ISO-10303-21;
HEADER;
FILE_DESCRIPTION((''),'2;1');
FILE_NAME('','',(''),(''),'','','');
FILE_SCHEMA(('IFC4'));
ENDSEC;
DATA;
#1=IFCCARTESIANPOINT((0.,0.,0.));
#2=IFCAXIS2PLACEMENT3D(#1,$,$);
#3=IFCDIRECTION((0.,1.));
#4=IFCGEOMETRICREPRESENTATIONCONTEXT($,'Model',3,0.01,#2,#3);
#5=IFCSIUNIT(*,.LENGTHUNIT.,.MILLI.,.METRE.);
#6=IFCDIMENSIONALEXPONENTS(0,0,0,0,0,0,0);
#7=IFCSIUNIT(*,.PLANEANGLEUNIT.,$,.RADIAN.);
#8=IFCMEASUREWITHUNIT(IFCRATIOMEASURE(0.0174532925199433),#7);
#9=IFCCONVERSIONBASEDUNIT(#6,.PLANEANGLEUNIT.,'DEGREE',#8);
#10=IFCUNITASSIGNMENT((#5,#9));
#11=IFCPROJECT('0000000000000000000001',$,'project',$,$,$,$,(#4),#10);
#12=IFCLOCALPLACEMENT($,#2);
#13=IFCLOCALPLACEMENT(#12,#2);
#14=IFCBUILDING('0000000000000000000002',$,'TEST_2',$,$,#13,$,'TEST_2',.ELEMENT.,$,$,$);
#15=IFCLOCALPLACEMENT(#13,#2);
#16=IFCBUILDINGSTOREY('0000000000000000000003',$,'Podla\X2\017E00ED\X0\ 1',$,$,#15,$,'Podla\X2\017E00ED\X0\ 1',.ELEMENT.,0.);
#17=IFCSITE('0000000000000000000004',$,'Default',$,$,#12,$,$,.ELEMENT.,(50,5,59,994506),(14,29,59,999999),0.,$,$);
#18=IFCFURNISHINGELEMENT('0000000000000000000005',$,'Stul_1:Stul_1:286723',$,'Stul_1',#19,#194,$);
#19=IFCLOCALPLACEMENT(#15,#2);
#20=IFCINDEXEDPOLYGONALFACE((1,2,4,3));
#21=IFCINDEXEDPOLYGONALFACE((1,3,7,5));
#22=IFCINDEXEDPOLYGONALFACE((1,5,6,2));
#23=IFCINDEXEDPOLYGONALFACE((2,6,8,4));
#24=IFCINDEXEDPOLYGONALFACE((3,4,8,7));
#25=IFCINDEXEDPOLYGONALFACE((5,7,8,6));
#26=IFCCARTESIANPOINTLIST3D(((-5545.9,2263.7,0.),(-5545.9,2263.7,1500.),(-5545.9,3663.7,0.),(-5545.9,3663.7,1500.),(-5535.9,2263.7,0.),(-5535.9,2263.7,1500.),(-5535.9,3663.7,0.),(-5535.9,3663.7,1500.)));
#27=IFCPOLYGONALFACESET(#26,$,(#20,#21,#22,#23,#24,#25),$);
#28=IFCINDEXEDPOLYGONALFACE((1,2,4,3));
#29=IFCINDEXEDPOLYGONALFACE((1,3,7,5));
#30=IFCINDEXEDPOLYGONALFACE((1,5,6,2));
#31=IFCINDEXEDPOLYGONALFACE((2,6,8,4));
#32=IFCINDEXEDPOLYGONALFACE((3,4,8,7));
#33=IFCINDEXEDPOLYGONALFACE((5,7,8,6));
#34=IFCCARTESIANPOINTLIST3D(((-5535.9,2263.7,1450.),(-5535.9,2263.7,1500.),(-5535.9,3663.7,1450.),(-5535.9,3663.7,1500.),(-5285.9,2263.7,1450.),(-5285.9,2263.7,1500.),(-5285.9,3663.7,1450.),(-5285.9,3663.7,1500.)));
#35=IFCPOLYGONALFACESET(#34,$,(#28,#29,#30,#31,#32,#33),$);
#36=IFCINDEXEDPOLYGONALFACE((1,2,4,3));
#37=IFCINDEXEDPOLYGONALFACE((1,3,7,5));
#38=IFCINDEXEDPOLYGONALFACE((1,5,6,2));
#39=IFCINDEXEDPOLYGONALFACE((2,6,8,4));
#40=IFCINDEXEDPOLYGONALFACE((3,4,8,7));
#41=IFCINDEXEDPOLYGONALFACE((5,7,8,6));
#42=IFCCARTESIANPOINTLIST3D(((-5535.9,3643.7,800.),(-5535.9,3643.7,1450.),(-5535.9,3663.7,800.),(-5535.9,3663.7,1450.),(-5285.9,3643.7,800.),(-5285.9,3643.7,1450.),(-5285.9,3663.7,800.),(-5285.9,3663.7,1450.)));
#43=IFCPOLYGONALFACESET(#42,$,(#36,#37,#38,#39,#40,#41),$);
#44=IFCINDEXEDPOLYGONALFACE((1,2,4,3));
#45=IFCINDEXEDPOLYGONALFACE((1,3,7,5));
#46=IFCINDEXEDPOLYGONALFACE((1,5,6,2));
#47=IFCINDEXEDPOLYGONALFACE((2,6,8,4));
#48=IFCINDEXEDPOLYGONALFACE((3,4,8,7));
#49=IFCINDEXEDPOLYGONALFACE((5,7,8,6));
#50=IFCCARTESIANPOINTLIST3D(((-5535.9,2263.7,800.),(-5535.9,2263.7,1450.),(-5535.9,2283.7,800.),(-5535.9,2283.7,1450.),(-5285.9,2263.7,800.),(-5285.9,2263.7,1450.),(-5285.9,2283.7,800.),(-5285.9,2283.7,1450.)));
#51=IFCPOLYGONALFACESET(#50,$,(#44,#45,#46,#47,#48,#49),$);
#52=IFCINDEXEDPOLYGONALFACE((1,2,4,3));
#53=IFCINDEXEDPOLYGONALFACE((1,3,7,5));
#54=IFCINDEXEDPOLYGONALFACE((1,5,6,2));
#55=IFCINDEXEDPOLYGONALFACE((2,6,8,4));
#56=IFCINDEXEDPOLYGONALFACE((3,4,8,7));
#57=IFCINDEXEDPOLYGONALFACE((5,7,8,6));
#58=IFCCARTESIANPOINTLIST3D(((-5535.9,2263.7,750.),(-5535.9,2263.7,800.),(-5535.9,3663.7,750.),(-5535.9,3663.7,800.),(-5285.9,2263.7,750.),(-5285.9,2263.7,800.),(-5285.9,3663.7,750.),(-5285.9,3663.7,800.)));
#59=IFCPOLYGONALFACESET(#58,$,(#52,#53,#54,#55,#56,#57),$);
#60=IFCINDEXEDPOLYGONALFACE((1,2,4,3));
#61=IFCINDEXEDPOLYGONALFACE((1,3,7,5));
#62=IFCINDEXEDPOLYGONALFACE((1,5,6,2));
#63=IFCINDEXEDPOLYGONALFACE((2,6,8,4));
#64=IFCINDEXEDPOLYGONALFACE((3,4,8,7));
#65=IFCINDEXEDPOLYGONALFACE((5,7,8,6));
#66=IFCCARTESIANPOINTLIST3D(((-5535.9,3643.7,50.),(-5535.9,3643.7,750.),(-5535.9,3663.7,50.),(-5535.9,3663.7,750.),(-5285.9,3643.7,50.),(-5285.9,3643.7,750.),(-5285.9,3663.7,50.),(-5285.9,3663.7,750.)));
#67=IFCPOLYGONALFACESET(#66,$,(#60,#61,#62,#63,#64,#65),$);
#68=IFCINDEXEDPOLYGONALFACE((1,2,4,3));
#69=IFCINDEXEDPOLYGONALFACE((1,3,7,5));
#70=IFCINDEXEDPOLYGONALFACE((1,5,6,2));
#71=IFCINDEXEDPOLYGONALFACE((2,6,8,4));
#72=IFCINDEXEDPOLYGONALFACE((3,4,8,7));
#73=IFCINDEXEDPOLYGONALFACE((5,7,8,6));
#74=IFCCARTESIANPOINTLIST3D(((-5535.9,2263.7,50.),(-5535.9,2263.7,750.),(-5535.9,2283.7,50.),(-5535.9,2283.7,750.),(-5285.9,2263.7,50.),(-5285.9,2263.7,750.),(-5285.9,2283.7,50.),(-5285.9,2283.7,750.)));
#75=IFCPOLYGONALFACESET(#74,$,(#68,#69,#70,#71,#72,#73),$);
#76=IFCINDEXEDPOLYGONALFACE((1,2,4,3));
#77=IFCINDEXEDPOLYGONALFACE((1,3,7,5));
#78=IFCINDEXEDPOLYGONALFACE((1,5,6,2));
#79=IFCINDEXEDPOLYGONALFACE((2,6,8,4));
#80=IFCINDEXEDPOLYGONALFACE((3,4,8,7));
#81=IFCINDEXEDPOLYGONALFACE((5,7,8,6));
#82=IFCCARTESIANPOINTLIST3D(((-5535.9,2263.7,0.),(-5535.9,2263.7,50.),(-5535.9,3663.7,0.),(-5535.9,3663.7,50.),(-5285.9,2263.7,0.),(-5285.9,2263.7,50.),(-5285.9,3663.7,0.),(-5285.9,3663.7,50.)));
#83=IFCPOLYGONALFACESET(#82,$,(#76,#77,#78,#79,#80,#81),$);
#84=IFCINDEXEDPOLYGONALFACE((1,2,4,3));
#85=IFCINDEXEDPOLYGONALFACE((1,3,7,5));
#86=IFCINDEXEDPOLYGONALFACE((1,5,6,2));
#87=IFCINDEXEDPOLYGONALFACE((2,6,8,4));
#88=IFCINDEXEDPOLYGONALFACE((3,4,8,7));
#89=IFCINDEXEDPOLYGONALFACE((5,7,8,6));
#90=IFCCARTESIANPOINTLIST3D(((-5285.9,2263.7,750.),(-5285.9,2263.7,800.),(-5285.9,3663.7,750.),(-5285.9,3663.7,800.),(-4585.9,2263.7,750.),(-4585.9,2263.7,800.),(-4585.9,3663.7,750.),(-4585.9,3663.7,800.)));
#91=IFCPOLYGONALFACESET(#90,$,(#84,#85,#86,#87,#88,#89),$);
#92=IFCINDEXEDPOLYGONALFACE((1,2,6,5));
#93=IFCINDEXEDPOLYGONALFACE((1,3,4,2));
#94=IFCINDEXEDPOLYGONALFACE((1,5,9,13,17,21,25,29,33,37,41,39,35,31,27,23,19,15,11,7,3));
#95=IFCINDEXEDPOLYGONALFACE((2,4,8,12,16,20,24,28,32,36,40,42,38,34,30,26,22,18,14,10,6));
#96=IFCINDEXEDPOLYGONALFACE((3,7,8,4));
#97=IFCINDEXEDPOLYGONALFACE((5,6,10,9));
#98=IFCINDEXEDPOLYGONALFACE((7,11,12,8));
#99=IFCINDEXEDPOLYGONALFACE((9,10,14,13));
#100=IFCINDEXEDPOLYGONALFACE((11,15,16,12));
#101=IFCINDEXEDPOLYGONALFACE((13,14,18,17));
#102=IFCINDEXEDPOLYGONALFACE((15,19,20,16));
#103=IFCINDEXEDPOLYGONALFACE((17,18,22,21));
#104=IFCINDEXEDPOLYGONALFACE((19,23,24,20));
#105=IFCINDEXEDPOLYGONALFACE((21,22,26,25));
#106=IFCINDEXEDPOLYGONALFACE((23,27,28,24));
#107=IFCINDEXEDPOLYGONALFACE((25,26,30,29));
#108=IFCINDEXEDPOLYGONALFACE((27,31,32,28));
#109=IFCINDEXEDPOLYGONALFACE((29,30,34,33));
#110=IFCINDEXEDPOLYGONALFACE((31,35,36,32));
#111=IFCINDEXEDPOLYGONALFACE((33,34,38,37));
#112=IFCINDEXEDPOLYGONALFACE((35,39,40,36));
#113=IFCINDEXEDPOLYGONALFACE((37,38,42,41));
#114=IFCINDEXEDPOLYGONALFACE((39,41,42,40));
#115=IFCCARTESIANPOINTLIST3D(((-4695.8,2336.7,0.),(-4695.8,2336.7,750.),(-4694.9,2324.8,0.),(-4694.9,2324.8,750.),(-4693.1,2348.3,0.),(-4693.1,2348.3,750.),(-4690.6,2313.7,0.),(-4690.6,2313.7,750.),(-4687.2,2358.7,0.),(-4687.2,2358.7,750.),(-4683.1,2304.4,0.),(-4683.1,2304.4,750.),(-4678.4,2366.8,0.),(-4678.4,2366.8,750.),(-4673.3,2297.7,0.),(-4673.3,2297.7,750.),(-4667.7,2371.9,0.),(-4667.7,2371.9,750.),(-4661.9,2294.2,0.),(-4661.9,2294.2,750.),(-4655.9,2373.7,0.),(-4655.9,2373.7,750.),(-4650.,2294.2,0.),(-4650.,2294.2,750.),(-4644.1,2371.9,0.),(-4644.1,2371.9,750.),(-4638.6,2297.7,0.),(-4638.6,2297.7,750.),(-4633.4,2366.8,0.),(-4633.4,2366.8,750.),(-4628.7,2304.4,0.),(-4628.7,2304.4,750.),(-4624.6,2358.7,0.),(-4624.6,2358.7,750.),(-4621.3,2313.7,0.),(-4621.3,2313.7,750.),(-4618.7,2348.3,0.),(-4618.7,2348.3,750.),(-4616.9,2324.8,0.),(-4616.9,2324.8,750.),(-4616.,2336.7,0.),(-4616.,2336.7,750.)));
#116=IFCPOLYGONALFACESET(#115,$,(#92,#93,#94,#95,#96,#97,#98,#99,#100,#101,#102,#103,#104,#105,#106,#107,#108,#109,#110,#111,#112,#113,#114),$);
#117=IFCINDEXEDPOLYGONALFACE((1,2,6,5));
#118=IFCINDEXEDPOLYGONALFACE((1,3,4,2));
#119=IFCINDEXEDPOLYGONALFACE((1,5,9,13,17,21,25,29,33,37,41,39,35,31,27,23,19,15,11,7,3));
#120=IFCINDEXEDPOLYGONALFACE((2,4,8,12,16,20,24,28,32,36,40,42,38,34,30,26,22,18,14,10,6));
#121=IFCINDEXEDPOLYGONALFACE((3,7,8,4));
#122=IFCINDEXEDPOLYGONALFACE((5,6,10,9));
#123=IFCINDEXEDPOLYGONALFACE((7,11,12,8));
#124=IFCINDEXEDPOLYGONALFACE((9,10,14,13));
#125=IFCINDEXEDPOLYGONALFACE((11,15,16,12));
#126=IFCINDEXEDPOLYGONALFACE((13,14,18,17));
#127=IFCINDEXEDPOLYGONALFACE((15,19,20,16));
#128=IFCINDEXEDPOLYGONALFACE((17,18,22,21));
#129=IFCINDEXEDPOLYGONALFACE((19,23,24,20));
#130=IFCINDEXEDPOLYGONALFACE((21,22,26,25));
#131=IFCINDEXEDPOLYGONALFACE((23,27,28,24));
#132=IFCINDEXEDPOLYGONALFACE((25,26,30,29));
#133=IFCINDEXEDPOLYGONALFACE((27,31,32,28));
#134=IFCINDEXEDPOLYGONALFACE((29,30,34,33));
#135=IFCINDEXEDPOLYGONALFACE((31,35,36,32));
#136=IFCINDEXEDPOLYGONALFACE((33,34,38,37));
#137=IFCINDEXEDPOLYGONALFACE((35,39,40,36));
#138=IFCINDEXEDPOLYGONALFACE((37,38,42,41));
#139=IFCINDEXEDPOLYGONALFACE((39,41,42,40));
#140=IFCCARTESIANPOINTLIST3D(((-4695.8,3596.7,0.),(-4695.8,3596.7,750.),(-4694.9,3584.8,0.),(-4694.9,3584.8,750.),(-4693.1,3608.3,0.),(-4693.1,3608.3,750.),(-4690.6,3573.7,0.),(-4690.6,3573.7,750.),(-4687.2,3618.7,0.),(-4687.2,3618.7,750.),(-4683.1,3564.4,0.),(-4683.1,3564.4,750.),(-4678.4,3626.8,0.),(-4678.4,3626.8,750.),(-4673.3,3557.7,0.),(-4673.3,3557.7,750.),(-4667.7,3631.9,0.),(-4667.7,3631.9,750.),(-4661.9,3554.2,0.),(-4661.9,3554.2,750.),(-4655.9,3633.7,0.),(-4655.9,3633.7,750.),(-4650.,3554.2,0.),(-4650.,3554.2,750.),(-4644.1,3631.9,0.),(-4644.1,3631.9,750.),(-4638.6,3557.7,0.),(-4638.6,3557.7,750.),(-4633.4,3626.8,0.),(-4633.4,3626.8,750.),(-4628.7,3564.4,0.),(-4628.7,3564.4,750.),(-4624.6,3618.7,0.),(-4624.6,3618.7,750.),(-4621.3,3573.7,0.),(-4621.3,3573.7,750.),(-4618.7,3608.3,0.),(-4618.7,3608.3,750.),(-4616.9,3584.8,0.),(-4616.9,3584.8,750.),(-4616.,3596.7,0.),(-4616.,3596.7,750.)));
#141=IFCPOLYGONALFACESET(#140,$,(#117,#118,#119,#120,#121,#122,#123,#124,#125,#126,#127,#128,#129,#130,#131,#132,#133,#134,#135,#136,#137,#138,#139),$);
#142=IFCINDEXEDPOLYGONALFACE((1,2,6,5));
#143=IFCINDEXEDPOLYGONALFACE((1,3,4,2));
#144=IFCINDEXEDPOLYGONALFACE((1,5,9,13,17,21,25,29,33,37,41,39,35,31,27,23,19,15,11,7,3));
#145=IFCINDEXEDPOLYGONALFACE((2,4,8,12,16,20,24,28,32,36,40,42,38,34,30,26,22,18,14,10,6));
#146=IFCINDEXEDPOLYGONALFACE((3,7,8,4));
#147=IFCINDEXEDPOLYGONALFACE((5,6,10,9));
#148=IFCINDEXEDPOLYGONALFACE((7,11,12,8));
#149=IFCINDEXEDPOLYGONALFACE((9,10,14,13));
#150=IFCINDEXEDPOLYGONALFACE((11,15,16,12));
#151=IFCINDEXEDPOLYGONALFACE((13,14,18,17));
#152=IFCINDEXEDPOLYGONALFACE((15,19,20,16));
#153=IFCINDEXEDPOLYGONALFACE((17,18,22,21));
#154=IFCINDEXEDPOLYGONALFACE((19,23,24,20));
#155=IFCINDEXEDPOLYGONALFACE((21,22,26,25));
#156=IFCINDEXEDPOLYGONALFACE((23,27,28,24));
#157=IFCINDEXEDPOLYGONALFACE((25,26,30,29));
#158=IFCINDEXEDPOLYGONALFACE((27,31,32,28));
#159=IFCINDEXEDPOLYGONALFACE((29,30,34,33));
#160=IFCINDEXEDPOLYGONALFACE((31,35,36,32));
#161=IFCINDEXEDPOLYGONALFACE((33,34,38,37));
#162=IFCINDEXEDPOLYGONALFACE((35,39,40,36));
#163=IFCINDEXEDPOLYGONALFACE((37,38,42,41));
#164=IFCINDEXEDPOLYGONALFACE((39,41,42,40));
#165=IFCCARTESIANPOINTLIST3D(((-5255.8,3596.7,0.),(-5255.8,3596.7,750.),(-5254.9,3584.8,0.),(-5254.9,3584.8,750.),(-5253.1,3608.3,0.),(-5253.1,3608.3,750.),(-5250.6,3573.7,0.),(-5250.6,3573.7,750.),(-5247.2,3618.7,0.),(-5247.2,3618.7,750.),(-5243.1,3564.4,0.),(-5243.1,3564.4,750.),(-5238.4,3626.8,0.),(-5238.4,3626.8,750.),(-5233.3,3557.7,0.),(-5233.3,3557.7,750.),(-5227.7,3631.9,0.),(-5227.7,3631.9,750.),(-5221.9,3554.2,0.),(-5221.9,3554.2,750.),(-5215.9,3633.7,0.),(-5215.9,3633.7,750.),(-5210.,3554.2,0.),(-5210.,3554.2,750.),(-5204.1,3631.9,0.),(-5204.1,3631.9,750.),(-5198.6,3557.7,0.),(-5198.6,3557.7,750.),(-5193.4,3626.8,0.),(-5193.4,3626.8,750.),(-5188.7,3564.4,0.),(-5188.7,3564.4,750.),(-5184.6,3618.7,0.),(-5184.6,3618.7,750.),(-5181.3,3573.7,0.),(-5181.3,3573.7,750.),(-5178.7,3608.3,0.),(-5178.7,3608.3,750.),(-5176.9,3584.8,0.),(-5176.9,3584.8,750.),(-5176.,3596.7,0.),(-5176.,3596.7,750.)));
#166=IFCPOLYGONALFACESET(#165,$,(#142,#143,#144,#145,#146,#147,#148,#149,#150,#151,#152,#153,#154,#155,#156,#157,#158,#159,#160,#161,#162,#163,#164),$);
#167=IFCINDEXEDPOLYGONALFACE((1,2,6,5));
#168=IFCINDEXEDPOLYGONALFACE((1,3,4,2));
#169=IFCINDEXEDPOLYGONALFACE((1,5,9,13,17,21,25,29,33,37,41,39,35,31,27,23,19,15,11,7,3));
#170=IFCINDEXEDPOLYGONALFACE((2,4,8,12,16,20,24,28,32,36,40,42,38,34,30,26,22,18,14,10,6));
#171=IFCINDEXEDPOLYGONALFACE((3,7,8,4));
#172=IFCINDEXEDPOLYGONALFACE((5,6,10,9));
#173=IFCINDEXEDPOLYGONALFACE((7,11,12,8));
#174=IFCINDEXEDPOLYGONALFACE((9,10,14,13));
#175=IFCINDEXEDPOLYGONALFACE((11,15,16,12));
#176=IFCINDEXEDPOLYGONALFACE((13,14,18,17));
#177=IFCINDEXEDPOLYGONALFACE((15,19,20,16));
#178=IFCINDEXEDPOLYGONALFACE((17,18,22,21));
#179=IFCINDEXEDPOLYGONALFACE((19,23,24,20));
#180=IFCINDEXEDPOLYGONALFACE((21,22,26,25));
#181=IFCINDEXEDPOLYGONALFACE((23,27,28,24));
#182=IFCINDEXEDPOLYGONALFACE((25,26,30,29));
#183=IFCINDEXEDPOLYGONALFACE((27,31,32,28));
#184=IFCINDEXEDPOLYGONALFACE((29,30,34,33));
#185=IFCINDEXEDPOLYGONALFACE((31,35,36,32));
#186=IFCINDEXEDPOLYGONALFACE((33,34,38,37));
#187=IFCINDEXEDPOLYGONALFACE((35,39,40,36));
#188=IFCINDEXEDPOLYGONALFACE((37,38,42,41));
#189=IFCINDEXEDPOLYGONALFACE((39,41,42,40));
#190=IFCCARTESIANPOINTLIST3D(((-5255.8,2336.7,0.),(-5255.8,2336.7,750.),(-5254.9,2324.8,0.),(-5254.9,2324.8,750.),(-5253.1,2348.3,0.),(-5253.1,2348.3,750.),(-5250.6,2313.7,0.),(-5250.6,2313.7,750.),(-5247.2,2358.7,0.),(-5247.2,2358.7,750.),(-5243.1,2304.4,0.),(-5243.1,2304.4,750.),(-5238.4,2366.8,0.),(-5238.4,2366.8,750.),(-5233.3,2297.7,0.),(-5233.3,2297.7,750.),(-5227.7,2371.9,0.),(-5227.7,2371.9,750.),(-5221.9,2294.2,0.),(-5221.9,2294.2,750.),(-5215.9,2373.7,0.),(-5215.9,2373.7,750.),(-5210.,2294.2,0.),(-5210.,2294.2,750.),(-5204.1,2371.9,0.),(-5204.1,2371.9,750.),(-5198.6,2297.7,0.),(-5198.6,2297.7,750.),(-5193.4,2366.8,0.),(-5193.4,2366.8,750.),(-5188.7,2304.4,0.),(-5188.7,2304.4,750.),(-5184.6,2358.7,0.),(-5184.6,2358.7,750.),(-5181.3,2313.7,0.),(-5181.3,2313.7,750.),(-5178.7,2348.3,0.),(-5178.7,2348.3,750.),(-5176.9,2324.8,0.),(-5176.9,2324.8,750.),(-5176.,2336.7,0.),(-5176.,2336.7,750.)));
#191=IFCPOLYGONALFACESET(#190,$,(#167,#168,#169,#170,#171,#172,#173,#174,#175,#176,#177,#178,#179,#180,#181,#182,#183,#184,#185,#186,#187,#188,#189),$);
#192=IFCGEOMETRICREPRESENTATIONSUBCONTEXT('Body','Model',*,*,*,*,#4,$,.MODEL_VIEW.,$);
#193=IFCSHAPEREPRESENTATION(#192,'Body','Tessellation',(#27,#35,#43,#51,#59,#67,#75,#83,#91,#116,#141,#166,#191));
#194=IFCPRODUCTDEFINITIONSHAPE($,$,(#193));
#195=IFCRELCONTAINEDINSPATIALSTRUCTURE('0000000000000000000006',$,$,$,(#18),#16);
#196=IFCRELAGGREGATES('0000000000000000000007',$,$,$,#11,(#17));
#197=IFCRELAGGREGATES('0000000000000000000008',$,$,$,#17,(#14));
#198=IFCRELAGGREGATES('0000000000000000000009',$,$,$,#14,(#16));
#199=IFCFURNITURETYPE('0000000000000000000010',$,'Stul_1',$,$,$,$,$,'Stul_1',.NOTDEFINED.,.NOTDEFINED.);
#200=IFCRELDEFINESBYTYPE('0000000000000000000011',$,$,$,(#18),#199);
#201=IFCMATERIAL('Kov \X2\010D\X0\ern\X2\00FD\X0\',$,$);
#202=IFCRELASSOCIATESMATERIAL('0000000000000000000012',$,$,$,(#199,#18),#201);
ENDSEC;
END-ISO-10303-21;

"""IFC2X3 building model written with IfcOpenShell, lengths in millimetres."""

from ifc_helpers import new_model, entity, si_unit, converted_unit, direction, frame, frame_2d, origin, origin_2d_with_axis, place, context, subcontext, project, spatial, rectangle, circle, extrude, source, transform, mapped, material, type_object, type_shapes, element, save


model = new_model("IFC2X3")

# Units and contexts
model_context = context("Model", 3, precision=0.01, world=origin(), true_north=direction((0.0, 1.0)))
body_context = subcontext(model_context, "Body", "Model", "MODEL_VIEW")
ifc_project = project(units=[si_unit("LENGTHUNIT", "METRE", prefix="MILLI"), converted_unit("PLANEANGLEUNIT", "DEGREE", entity("IfcRatioMeasure", 0.0174532925199433), si_unit("PLANEANGLEUNIT", "RADIAN"), dimensions=[0, 0, 0, 0, 0, 0, 0])], contexts=[model_context])

# Site, building, storey
site_placement = place(None, origin())
site = spatial("IfcSite", under=ifc_project, at=site_placement, Name="Default", CompositionType="ELEMENT", RefLatitude=(50, 5, 59, 994506), RefLongitude=(14, 29, 59, 999999), RefElevation=0.0)
building_placement = place(site_placement, origin())
building = spatial("IfcBuilding", under=site, at=building_placement, Name="TEST_2", LongName="TEST_2", CompositionType="ELEMENT")
storey_placement = place(building_placement, origin())
storey = spatial("IfcBuildingStorey", under=building, at=storey_placement, Name="Podlaží 1", LongName="Podlaží 1", CompositionType="ELEMENT", Elevation=0.0)

# Furnishing element
ifc_material_1 = material(Name="Kov černý")
furniture_type = type_object("IfcFurnitureType", Name="Stul_1", ElementType="Stul_1", material=ifc_material_1)
shared_shape_1 = source(origin(), body_context, "Body", "SweptSolid", [
    extrude(rectangle(XDim=1400.0, YDim=10.0, at=origin_2d_with_axis()), frame((0.0, 605.0, 0.0), z_axis=(0.0, 0.0, 1.0), x_axis=(-1.0, 0.0, 0.0)), (0.0, 0.0, 1.0), 1500.0),
    extrude(rectangle(XDim=1400.0, YDim=250.0, at=frame_2d((0.0, 0.0), x_axis=(1.0, 0.0))), frame((0.0, 475.0, 1450.0), z_axis=(0.0, 0.0, 1.0), x_axis=(-1.0, 0.0, 0.0)), (0.0, 0.0, 1.0), 50.0),
    extrude(rectangle(XDim=20.0, YDim=250.0, at=origin_2d_with_axis()), frame((690.0, 475.0, 800.0), z_axis=(0.0, 0.0, 1.0), x_axis=(-1.0, 0.0, 0.0)), (0.0, 0.0, 1.0), 650.0),
    extrude(rectangle(XDim=20.0, YDim=250.0, at=frame_2d((0.0, 0.0), x_axis=(1.0, 0.0))), frame((-690.0, 475.0, 800.0), z_axis=(0.0, 0.0, 1.0), x_axis=(-1.0, 0.0, 0.0)), (0.0, 0.0, 1.0), 650.0),
    extrude(rectangle(XDim=1400.0, YDim=250.0, at=origin_2d_with_axis()), frame((0.0, 475.0, 750.0), z_axis=(0.0, 0.0, 1.0), x_axis=(-1.0, 0.0, 0.0)), (0.0, 0.0, 1.0), 50.0),
    extrude(rectangle(XDim=20.0, YDim=250.0, at=origin_2d_with_axis()), frame((690.0, 475.0, 50.0), z_axis=(0.0, 0.0, 1.0), x_axis=(-1.0, 0.0, 0.0)), (0.0, 0.0, 1.0), 700.0),
    extrude(rectangle(XDim=20.0, YDim=250.0, at=frame_2d((0.0, 0.0), x_axis=(1.0, 0.0))), frame((-690.0, 475.0, 50.0), z_axis=(0.0, 0.0, 1.0), x_axis=(-1.0, 0.0, 0.0)), (0.0, 0.0, 1.0), 700.0),
    extrude(rectangle(XDim=1400.0, YDim=250.0, at=origin_2d_with_axis()), frame((0.0, 475.0, 0.0), z_axis=(0.0, 0.0, 1.0), x_axis=(-1.0, 0.0, 0.0)), (0.0, 0.0, 1.0), 50.0),
    extrude(rectangle(XDim=1400.0, YDim=700.0, at=origin_2d_with_axis()), frame((0.0, 0.0, 750.0), z_axis=(0.0, 0.0, 1.0), x_axis=(-1.0, 0.0, 0.0)), (0.0, 0.0, 1.0), 50.0),
    extrude(circle(Radius=40.0, at=frame_2d((0.0, 0.0), x_axis=(1.0, 0.0))), frame((-630.0, -280.0, 0.0)), (0.0, 0.0, 1.0), 750.0),
    extrude(circle(Radius=40.0, at=frame_2d((0.0, 0.0), x_axis=(1.0, 0.0))), frame((630.0, -280.0, 0.0)), (0.0, 0.0, 1.0), 750.0),
    extrude(circle(Radius=40.0, at=frame_2d((0.0, 0.0), x_axis=(1.0, 0.0))), frame((630.0, 280.0, 0.0)), (0.0, 0.0, 1.0), 750.0),
    extrude(circle(Radius=40.0, at=frame_2d((0.0, 0.0), x_axis=(1.0, 0.0))), frame((-630.0, 280.0, 0.0)), (0.0, 0.0, 1.0), 750.0),
])
type_shapes(furniture_type, [shared_shape_1])
for number, where, z_axis, x_axis, name in (
    (1, (-4935.9, 2963.7, 0.0), (0.0, 0.0, 1.0), (0.0, 1.0, 0.0), "Stul_1:Stul_1:286723"),
):
    element("IfcFurnishingElement", number, at=place(storey_placement, frame(where, z_axis=z_axis, x_axis=x_axis)), inside=storey, type_object=furniture_type, material=ifc_material_1, Name=name, ObjectType="Stul_1", context=body_context, shape_type="MappedRepresentation", body=[
        mapped(shared_shape_1, transform((0.0, 0.0, 0.0), scale=1.0)),
    ])

save(model, "model.ifc")
